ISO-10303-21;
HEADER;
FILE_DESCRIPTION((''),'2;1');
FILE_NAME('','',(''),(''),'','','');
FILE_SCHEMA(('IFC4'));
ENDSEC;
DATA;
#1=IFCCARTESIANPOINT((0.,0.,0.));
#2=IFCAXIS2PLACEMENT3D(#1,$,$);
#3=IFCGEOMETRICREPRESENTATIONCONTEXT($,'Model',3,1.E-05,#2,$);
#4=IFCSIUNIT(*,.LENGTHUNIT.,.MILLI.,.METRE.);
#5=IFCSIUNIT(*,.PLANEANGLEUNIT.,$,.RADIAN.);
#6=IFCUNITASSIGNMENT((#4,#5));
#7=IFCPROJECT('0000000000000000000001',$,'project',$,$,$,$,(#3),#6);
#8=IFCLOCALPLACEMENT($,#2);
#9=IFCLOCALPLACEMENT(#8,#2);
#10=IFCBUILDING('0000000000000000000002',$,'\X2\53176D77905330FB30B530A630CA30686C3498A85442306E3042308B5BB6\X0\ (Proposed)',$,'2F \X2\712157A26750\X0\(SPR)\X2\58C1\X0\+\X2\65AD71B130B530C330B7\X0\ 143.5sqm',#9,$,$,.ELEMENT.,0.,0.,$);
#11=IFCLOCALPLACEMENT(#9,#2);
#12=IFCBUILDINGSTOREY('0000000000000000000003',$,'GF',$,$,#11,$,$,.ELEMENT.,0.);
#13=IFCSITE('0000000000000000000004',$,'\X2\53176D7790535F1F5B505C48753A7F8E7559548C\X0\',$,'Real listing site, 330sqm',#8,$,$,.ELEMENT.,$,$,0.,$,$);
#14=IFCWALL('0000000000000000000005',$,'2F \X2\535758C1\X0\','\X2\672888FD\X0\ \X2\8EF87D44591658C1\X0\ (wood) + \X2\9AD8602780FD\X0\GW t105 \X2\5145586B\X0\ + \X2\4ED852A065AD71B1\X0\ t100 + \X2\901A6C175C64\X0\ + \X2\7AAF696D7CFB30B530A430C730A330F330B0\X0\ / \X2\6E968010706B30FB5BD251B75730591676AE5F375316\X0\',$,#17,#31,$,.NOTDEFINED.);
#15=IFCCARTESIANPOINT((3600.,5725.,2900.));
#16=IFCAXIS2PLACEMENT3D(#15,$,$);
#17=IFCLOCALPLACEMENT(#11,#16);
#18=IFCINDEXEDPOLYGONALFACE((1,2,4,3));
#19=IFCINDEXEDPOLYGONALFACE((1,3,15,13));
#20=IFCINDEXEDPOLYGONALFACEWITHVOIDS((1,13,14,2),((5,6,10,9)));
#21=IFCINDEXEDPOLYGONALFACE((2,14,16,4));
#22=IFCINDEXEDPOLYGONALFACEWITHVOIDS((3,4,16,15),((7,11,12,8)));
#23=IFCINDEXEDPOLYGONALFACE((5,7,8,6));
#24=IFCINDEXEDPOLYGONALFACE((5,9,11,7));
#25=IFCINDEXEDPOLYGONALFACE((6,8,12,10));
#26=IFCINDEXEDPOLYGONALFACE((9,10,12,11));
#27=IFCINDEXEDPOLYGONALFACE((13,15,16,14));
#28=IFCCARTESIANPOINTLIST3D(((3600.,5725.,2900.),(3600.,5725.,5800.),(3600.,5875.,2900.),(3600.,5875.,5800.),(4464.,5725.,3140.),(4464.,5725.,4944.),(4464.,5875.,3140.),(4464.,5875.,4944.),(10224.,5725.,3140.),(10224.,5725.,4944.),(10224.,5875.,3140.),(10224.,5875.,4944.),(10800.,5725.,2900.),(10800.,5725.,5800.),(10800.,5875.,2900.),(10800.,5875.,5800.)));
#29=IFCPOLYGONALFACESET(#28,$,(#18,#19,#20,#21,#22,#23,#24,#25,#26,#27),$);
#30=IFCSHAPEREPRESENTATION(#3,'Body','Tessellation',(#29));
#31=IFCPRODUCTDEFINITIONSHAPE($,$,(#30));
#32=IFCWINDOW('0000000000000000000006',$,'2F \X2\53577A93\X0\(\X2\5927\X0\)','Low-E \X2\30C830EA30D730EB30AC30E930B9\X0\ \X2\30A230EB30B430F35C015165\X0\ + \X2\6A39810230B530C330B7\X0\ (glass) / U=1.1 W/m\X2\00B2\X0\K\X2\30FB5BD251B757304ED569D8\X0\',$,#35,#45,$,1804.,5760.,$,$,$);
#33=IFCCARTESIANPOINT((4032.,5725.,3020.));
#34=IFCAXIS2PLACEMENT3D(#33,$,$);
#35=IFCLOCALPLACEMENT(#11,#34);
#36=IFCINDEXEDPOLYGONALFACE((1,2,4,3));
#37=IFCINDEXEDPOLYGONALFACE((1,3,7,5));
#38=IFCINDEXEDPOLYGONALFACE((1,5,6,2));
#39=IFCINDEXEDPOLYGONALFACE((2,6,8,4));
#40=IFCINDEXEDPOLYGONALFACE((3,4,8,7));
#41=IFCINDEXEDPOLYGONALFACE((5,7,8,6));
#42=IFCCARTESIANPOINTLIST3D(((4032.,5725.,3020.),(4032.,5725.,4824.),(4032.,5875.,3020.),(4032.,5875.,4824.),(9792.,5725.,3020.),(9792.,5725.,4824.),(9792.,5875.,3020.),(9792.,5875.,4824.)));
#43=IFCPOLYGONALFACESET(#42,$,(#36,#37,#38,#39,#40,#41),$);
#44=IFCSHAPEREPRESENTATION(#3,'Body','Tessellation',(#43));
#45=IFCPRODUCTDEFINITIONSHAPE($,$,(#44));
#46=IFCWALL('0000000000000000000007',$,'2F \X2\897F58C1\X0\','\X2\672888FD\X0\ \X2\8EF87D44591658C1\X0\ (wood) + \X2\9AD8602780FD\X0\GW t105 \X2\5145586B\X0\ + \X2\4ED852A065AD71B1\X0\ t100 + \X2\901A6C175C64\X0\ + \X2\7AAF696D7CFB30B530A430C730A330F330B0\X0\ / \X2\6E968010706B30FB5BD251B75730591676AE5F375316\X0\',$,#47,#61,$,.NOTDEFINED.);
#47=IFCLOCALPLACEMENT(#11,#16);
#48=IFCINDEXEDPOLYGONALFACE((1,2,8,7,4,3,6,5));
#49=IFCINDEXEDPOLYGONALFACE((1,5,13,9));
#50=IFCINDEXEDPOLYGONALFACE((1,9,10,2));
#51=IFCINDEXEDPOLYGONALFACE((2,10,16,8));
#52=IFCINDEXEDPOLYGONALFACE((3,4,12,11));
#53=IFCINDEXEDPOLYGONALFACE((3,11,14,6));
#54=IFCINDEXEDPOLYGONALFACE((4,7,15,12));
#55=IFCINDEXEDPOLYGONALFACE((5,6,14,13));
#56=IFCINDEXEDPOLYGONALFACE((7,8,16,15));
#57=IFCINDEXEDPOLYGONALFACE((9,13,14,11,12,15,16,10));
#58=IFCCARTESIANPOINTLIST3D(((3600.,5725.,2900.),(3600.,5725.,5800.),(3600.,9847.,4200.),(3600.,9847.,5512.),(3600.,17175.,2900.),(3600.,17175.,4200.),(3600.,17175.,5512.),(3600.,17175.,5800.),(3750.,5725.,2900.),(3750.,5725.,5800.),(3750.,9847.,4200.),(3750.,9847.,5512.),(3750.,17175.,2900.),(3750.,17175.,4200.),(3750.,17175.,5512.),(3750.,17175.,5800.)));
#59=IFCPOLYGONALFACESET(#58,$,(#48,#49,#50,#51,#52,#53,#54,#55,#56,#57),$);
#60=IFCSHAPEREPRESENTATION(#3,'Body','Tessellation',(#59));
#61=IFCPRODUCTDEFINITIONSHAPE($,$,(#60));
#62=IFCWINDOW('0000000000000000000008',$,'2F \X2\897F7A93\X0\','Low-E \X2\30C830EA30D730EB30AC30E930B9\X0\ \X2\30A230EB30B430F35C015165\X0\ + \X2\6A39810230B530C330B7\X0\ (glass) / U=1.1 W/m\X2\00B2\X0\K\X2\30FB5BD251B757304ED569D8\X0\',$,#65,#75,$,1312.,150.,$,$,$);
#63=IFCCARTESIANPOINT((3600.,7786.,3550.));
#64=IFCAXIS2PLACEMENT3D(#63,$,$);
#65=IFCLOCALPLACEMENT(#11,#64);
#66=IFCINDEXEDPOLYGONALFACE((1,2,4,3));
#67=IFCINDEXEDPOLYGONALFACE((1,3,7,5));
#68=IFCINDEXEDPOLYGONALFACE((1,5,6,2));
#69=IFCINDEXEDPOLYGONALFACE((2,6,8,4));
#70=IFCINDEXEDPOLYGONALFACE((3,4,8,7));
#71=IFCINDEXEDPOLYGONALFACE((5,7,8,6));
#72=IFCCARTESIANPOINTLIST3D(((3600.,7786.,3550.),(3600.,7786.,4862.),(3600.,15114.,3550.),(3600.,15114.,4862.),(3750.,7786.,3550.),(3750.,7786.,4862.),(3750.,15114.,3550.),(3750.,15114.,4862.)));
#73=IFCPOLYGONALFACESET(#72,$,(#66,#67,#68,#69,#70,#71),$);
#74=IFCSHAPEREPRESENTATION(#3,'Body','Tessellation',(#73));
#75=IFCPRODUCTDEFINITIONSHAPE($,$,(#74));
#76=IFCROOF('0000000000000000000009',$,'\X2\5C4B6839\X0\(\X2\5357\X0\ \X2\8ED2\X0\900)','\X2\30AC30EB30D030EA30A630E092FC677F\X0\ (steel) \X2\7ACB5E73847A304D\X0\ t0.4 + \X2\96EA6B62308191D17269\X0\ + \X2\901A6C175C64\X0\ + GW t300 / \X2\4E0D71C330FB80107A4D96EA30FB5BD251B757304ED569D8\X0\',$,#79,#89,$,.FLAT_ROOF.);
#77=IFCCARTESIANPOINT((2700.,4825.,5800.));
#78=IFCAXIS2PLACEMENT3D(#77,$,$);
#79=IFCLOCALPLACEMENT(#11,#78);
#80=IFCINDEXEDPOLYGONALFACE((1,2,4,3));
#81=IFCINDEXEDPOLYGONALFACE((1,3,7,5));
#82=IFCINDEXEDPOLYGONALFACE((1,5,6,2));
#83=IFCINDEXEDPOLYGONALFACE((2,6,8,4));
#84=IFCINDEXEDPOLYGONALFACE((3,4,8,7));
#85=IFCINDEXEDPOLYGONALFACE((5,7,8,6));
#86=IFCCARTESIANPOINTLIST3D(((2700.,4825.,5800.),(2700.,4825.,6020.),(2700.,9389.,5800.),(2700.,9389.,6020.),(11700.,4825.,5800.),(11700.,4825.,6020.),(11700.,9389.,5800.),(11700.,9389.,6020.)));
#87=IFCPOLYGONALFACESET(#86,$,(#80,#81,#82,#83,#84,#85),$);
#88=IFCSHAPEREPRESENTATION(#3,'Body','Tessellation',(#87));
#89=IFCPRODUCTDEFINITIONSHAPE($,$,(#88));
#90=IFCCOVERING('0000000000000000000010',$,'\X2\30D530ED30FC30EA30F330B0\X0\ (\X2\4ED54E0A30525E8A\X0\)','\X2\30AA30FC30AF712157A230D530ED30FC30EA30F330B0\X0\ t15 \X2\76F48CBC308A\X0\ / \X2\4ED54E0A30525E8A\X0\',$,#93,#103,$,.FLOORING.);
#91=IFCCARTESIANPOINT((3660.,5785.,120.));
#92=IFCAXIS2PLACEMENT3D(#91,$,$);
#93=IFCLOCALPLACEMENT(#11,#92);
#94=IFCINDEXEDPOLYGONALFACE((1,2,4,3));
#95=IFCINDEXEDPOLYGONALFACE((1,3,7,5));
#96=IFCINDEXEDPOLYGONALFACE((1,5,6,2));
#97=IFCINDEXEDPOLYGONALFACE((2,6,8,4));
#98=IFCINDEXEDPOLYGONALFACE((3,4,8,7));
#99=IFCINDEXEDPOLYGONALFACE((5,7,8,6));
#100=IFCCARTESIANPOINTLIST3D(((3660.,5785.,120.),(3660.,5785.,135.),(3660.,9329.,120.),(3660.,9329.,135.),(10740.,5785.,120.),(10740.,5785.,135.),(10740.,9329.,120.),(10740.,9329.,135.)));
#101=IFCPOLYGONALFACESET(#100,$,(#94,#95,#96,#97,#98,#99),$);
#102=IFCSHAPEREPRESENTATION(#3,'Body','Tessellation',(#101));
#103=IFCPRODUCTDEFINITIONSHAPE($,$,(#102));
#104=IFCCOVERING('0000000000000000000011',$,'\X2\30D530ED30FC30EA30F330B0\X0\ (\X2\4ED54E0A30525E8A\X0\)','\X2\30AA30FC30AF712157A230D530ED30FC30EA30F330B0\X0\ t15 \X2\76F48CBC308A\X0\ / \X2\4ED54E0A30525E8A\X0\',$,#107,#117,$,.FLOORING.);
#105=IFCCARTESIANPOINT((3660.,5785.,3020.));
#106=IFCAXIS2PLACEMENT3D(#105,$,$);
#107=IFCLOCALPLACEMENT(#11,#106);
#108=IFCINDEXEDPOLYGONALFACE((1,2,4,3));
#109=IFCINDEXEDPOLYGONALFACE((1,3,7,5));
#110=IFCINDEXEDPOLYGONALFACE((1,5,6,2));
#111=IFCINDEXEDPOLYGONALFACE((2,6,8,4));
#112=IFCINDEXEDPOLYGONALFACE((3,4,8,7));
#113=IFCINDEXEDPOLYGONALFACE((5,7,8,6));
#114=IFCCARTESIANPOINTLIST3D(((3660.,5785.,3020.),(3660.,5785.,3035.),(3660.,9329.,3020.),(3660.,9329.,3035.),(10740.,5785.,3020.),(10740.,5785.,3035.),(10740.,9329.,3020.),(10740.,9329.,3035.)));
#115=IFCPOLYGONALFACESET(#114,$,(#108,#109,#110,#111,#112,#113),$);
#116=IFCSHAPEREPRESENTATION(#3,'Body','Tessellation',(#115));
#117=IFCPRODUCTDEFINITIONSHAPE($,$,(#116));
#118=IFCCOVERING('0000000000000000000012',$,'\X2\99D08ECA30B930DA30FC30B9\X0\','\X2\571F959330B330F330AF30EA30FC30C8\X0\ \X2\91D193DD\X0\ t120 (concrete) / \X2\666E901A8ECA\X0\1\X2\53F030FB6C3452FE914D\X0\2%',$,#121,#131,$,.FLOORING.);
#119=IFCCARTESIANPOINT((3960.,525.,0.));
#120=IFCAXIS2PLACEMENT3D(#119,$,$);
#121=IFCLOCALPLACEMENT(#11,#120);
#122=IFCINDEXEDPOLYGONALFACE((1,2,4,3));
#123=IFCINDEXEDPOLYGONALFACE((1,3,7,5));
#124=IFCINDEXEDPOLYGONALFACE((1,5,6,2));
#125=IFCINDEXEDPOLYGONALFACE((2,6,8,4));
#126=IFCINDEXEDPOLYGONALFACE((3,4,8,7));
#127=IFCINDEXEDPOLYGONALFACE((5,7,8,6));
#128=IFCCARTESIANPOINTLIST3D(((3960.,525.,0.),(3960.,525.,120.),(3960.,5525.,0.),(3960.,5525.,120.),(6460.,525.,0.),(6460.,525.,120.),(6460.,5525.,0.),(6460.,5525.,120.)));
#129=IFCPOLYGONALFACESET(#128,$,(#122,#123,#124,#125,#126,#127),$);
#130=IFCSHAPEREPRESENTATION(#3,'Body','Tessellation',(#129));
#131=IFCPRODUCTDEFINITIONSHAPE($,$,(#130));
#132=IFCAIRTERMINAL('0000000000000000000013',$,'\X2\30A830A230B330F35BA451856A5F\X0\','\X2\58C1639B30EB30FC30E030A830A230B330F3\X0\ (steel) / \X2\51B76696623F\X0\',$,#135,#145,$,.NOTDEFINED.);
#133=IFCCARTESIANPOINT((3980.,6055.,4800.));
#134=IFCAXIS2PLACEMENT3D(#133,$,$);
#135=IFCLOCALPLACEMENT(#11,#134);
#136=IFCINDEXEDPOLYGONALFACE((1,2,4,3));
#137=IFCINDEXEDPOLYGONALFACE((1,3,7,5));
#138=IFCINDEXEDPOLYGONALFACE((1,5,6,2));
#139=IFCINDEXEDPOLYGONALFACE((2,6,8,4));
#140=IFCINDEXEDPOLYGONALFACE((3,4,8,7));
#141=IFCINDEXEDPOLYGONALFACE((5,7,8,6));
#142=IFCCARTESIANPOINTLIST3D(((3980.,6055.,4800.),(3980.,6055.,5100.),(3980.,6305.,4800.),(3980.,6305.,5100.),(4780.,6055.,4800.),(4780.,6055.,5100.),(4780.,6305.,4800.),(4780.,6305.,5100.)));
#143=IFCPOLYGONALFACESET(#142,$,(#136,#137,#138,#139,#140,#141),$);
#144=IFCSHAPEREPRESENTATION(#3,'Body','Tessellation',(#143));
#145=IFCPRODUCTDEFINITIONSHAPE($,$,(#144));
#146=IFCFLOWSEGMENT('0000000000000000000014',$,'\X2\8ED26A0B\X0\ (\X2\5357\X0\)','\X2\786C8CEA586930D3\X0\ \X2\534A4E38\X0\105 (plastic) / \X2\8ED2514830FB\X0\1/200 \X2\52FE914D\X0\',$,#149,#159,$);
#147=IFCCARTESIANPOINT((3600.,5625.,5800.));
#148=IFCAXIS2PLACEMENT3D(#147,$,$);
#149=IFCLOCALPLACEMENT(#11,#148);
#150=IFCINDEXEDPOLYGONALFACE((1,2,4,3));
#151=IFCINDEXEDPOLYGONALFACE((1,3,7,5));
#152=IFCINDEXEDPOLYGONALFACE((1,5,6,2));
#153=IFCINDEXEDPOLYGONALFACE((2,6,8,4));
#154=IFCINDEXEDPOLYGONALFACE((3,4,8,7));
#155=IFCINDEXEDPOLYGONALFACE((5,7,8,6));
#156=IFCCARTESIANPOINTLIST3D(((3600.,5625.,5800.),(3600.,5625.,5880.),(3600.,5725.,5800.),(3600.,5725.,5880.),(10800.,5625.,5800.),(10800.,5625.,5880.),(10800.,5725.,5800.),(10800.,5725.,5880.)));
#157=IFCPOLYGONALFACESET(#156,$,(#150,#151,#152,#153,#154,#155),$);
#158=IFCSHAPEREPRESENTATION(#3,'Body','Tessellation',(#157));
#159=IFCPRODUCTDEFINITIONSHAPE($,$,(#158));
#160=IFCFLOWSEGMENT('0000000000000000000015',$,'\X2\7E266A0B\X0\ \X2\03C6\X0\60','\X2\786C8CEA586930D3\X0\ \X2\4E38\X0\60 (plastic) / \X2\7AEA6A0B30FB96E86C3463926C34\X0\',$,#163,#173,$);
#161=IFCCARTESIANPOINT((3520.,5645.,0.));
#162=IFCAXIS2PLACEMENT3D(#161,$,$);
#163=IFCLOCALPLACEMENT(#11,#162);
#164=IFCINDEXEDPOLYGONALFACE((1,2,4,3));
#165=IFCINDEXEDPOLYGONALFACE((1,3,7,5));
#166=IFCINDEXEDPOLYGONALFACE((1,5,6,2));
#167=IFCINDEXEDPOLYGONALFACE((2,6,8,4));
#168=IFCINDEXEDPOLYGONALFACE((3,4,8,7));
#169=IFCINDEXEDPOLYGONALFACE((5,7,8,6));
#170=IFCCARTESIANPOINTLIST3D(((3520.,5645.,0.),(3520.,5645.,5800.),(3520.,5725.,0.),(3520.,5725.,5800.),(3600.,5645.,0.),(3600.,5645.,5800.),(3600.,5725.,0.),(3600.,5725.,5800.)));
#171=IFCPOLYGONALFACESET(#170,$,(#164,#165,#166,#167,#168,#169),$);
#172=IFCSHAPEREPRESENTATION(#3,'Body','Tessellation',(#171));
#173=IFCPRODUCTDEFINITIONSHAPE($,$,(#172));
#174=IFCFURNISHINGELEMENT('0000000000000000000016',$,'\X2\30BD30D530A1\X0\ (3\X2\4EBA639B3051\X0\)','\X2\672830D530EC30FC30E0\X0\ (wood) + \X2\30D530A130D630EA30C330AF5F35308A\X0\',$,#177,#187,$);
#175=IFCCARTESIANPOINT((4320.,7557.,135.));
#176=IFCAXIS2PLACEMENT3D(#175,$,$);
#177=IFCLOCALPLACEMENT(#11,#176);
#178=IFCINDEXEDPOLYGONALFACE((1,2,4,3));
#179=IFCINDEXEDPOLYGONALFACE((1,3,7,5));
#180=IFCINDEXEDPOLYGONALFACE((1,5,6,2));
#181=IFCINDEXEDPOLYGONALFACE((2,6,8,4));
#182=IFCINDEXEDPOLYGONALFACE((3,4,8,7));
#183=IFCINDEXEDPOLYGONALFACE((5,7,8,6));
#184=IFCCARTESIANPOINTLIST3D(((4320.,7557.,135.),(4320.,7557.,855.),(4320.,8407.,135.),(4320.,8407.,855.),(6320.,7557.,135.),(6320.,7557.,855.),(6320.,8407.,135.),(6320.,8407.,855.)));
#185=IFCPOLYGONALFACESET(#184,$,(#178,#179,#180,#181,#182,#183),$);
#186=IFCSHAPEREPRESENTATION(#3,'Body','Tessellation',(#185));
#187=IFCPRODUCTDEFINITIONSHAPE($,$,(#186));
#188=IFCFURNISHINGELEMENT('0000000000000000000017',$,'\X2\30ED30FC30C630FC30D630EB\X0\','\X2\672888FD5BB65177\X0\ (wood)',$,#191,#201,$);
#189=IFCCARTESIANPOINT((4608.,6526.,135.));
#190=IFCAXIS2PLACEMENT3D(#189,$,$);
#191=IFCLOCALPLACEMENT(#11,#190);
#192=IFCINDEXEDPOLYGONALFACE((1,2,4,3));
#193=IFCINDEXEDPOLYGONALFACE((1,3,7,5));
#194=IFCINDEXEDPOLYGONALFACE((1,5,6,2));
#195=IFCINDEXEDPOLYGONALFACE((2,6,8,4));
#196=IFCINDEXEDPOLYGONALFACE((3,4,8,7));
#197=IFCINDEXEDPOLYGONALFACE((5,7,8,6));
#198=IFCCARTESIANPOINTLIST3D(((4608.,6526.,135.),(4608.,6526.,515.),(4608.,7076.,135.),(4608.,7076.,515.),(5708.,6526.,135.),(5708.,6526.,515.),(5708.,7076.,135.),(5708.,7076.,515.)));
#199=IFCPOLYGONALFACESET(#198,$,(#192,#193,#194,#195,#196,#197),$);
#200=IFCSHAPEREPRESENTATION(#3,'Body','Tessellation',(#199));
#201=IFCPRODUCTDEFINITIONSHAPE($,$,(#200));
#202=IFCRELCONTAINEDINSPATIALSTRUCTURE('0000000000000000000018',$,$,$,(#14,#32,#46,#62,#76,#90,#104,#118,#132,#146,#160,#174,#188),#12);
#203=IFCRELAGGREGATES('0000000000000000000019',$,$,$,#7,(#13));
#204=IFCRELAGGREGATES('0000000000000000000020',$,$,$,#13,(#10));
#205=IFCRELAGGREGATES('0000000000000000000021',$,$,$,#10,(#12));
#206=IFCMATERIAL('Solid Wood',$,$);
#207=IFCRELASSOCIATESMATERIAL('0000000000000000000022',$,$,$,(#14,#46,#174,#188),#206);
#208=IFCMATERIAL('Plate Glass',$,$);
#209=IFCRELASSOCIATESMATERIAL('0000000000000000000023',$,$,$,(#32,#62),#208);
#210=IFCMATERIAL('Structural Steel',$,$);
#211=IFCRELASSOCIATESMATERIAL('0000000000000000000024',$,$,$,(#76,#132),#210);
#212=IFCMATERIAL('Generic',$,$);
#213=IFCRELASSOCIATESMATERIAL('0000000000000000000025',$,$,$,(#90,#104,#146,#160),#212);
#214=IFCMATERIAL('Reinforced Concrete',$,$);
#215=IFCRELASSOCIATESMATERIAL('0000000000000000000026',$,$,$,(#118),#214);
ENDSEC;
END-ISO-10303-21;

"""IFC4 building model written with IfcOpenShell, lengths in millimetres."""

from ifc_helpers import new_model, si_unit, frame, frame_2d, origin, place, context, project, spatial, rectangle, extrude, material, element, fill, save


model = new_model("IFC4")

# Units and contexts
model_context = context("Model", 3, precision=1e-05, world=origin())
ifc_project = project(units=[si_unit("LENGTHUNIT", "METRE", prefix="MILLI"), si_unit("PLANEANGLEUNIT", "RADIAN")], contexts=[model_context])

# Site, building, storey
site_placement = place(None, origin())
site = spatial("IfcSite", under=ifc_project, at=site_placement, Name="北海道弟子屈町美留和", ObjectType="Real listing site, 330sqm", CompositionType="ELEMENT", RefElevation=0.0)
building_placement = place(site_placement, origin())
building = spatial("IfcBuilding", under=site, at=building_placement, Name="北海道・サウナと水風呂のある家 (Proposed)", ObjectType="2F 無垢材(SPR)壁+断熱サッシ 143.5sqm", CompositionType="ELEMENT", ElevationOfRefHeight=0.0, ElevationOfTerrain=0.0)
storey_placement = place(building_placement, origin())
storey = spatial("IfcBuildingStorey", under=building, at=storey_placement, Name="GF", CompositionType="ELEMENT", Elevation=0.0)

# Shared definitions
ifc_material_1 = material(Name="Solid Wood")

# Shared definitions
ifc_material_2 = material(Name="Reinforced Concrete")

# Shared definitions
ifc_material_3 = material(Name="Plate Glass")

# Walls, openings, windows
wall_1_placement = place(storey_placement, frame((3600.0, 5725.0, 2900.0)))
wall_1 = element("IfcWall", 1, at=wall_1_placement, inside=storey, material=ifc_material_1, Name="2F 南壁", Description="木製 軸組外壁 (wood) + 高性能GW t105 充填 + 付加断熱 t100 + 通気層 + 窯業系サイディング / 準耐火・寒冷地外皮強化", PredefinedType="NOTDEFINED", context=model_context, shape_type="SweptSolid", body=[
    extrude(rectangle(XDim=7200.0, YDim=150.0, at=frame_2d((3600.0, 75.0))), frame((3600.0, 5725.0, 2900.0)), (0.0, 0.0, 1.0), 2900.0),
])
opening_1_placement = place(storey_placement, frame((4032.0, 5725.0, 3020.0)))
opening_1 = element("IfcOpeningElement", 2, at=opening_1_placement, cuts=wall_1, PredefinedType="NOTDEFINED", context=model_context, shape_type="SweptSolid", body=[
    extrude(rectangle(XDim=5760.0, YDim=150.0, at=frame_2d((2880.0, 75.0))), frame((4032.0, 5725.0, 3020.0)), (0.0, 0.0, 1.0), 1804.0),
])
window_1_placement = place(storey_placement, frame((4032.0, 5725.0, 3020.0)))
window_1 = element("IfcWindow", 3, at=window_1_placement, inside=storey, material=ifc_material_3, Name="2F 南窓(大)", Description="Low-E トリプルガラス アルゴン封入 + 樹脂サッシ (glass) / U=1.1 W/m²K・寒冷地仕様", OverallHeight=1804.0, OverallWidth=5760.0, context=model_context, shape_type="SweptSolid", body=[
    extrude(rectangle(XDim=5760.0, YDim=150.0, at=frame_2d((2880.0, 75.0))), frame((4032.0, 5725.0, 3020.0)), (0.0, 0.0, 1.0), 1804.0),
])
fill(opening_1, window_1)
wall_2_placement = place(storey_placement, frame((3600.0, 5725.0, 2900.0)))
wall_2 = element("IfcWall", 4, at=wall_2_placement, inside=storey, material=ifc_material_1, Name="2F 西壁", Description="木製 軸組外壁 (wood) + 高性能GW t105 充填 + 付加断熱 t100 + 通気層 + 窯業系サイディング / 準耐火・寒冷地外皮強化", PredefinedType="NOTDEFINED", context=model_context, shape_type="SweptSolid", body=[
    extrude(rectangle(XDim=150.0, YDim=11450.0, at=frame_2d((75.0, 5725.0))), frame((3600.0, 5725.0, 2900.0)), (0.0, 0.0, 1.0), 2900.0),
])
opening_2_placement = place(storey_placement, frame((3600.0, 7786.0, 3550.0)))
opening_2 = element("IfcOpeningElement", 5, at=opening_2_placement, cuts=wall_2, PredefinedType="NOTDEFINED", context=model_context, shape_type="SweptSolid", body=[
    extrude(rectangle(XDim=150.0, YDim=7328.0, at=frame_2d((75.0, 3664.0))), frame((3600.0, 7786.0, 3550.0)), (0.0, 0.0, 1.0), 1312.0),
])
window_2_placement = place(storey_placement, frame((3600.0, 7786.0, 3550.0)))
window_2 = element("IfcWindow", 6, at=window_2_placement, inside=storey, material=ifc_material_3, Name="2F 西窓", Description="Low-E トリプルガラス アルゴン封入 + 樹脂サッシ (glass) / U=1.1 W/m²K・寒冷地仕様", OverallHeight=1312.0, OverallWidth=150.0, context=model_context, shape_type="SweptSolid", body=[
    extrude(rectangle(XDim=150.0, YDim=7328.0, at=frame_2d((75.0, 3664.0))), frame((3600.0, 7786.0, 3550.0)), (0.0, 0.0, 1.0), 1312.0),
])
fill(opening_2, window_2)

# Roof
ifc_material_4 = material(Name="Structural Steel")
for number, where, name in (
    (7, (2700.0, 4825.0, 5800.0), "屋根(南 軒900)"),
):
    element("IfcRoof", number, at=place(storey_placement, frame(where)), inside=storey, material=ifc_material_4, Name=name, Description="ガルバリウム鋼板 (steel) 立平葺き t0.4 + 雪止め金物 + 通気層 + GW t300 / 不燃・耐積雪・寒冷地仕様", PredefinedType="FLAT_ROOF", context=model_context, shape_type="SweptSolid", body=[
        extrude(rectangle(XDim=9000.0, YDim=4564.0, at=frame_2d((4500.0, 2282.0))), frame((2700.0, 4825.0, 5800.0)), (0.0, 0.0, 1.0), 220.0),
    ])

# Coverings
ifc_material_5 = material(Name="Generic")
covering_1_placement = place(storey_placement, frame((3660.0, 5785.0, 120.0)))
element("IfcCovering", 8, at=covering_1_placement, inside=storey, material=ifc_material_5, Name="フローリング (仕上げ床)", Description="オーク無垢フローリング t15 直貼り / 仕上げ床", PredefinedType="FLOORING", context=model_context, shape_type="SweptSolid", body=[
    extrude(rectangle(XDim=7080.0, YDim=3544.0, at=frame_2d((3540.0, 1772.0))), frame((3660.0, 5785.0, 120.0)), (0.0, 0.0, 1.0), 15.0),
])
covering_2_placement = place(storey_placement, frame((3660.0, 5785.0, 3020.0)))
element("IfcCovering", 9, at=covering_2_placement, inside=storey, material=ifc_material_5, Name="フローリング (仕上げ床)", Description="オーク無垢フローリング t15 直貼り / 仕上げ床", PredefinedType="FLOORING", context=model_context, shape_type="SweptSolid", body=[
    extrude(rectangle(XDim=7080.0, YDim=3544.0, at=frame_2d((3540.0, 1772.0))), frame((3660.0, 5785.0, 3020.0)), (0.0, 0.0, 1.0), 15.0),
])
covering_3_placement = place(storey_placement, frame((3960.0, 525.0, 0.0)))
element("IfcCovering", 10, at=covering_3_placement, inside=storey, material=ifc_material_2, Name="駐車スペース", Description="土間コンクリート 金鏝 t120 (concrete) / 普通車1台・水勾配2%", PredefinedType="FLOORING", context=model_context, shape_type="SweptSolid", body=[
    extrude(rectangle(XDim=2500.0, YDim=5000.0, at=frame_2d((1250.0, 2500.0))), frame((3960.0, 525.0, 0.0)), (0.0, 0.0, 1.0), 120.0),
])

# Air terminal
air_terminal_placement = place(storey_placement, frame((3980.0, 6055.0, 4800.0)))
element("IfcAirTerminal", 11, at=air_terminal_placement, inside=storey, material=ifc_material_4, Name="エアコン室内機", Description="壁掛ルームエアコン (steel) / 冷暖房", PredefinedType="NOTDEFINED", context=model_context, shape_type="SweptSolid", body=[
    extrude(rectangle(XDim=800.0, YDim=250.0, at=frame_2d((400.0, 125.0))), frame((3980.0, 6055.0, 4800.0)), (0.0, 0.0, 1.0), 300.0),
])

# Flow segments
flow_segment_1_placement = place(storey_placement, frame((3600.0, 5625.0, 5800.0)))
element("IfcFlowSegment", 12, at=flow_segment_1_placement, inside=storey, material=ifc_material_5, Name="軒樋 (南)", Description="硬質塩ビ 半丸105 (plastic) / 軒先・1/200 勾配", context=model_context, shape_type="SweptSolid", body=[
    extrude(rectangle(XDim=7200.0, YDim=100.0, at=frame_2d((3600.0, 50.0))), frame((3600.0, 5625.0, 5800.0)), (0.0, 0.0, 1.0), 80.0),
])
flow_segment_2_placement = place(storey_placement, frame((3520.0, 5645.0, 0.0)))
element("IfcFlowSegment", 13, at=flow_segment_2_placement, inside=storey, material=ifc_material_5, Name="縦樋 φ60", Description="硬質塩ビ 丸60 (plastic) / 竪樋・雨水排水", context=model_context, shape_type="SweptSolid", body=[
    extrude(rectangle(XDim=80.0, YDim=80.0, at=frame_2d((40.0, 40.0))), frame((3520.0, 5645.0, 0.0)), (0.0, 0.0, 1.0), 5800.0),
])

# Furnishing elements
furnishing_1_placement = place(storey_placement, frame((4320.0, 7557.0, 135.0)))
element("IfcFurnishingElement", 14, at=furnishing_1_placement, inside=storey, material=ifc_material_1, Name="ソファ (3人掛け)", Description="木フレーム (wood) + ファブリック張り", context=model_context, shape_type="SweptSolid", body=[
    extrude(rectangle(XDim=2000.0, YDim=850.0, at=frame_2d((1000.0, 425.0))), frame((4320.0, 7557.0, 135.0)), (0.0, 0.0, 1.0), 720.0),
])
furnishing_2_placement = place(storey_placement, frame((4608.0, 6526.0, 135.0)))
element("IfcFurnishingElement", 15, at=furnishing_2_placement, inside=storey, material=ifc_material_1, Name="ローテーブル", Description="木製家具 (wood)", context=model_context, shape_type="SweptSolid", body=[
    extrude(rectangle(XDim=1100.0, YDim=550.0, at=frame_2d((550.0, 275.0))), frame((4608.0, 6526.0, 135.0)), (0.0, 0.0, 1.0), 380.0),
])

save(model, "model.ifc")
